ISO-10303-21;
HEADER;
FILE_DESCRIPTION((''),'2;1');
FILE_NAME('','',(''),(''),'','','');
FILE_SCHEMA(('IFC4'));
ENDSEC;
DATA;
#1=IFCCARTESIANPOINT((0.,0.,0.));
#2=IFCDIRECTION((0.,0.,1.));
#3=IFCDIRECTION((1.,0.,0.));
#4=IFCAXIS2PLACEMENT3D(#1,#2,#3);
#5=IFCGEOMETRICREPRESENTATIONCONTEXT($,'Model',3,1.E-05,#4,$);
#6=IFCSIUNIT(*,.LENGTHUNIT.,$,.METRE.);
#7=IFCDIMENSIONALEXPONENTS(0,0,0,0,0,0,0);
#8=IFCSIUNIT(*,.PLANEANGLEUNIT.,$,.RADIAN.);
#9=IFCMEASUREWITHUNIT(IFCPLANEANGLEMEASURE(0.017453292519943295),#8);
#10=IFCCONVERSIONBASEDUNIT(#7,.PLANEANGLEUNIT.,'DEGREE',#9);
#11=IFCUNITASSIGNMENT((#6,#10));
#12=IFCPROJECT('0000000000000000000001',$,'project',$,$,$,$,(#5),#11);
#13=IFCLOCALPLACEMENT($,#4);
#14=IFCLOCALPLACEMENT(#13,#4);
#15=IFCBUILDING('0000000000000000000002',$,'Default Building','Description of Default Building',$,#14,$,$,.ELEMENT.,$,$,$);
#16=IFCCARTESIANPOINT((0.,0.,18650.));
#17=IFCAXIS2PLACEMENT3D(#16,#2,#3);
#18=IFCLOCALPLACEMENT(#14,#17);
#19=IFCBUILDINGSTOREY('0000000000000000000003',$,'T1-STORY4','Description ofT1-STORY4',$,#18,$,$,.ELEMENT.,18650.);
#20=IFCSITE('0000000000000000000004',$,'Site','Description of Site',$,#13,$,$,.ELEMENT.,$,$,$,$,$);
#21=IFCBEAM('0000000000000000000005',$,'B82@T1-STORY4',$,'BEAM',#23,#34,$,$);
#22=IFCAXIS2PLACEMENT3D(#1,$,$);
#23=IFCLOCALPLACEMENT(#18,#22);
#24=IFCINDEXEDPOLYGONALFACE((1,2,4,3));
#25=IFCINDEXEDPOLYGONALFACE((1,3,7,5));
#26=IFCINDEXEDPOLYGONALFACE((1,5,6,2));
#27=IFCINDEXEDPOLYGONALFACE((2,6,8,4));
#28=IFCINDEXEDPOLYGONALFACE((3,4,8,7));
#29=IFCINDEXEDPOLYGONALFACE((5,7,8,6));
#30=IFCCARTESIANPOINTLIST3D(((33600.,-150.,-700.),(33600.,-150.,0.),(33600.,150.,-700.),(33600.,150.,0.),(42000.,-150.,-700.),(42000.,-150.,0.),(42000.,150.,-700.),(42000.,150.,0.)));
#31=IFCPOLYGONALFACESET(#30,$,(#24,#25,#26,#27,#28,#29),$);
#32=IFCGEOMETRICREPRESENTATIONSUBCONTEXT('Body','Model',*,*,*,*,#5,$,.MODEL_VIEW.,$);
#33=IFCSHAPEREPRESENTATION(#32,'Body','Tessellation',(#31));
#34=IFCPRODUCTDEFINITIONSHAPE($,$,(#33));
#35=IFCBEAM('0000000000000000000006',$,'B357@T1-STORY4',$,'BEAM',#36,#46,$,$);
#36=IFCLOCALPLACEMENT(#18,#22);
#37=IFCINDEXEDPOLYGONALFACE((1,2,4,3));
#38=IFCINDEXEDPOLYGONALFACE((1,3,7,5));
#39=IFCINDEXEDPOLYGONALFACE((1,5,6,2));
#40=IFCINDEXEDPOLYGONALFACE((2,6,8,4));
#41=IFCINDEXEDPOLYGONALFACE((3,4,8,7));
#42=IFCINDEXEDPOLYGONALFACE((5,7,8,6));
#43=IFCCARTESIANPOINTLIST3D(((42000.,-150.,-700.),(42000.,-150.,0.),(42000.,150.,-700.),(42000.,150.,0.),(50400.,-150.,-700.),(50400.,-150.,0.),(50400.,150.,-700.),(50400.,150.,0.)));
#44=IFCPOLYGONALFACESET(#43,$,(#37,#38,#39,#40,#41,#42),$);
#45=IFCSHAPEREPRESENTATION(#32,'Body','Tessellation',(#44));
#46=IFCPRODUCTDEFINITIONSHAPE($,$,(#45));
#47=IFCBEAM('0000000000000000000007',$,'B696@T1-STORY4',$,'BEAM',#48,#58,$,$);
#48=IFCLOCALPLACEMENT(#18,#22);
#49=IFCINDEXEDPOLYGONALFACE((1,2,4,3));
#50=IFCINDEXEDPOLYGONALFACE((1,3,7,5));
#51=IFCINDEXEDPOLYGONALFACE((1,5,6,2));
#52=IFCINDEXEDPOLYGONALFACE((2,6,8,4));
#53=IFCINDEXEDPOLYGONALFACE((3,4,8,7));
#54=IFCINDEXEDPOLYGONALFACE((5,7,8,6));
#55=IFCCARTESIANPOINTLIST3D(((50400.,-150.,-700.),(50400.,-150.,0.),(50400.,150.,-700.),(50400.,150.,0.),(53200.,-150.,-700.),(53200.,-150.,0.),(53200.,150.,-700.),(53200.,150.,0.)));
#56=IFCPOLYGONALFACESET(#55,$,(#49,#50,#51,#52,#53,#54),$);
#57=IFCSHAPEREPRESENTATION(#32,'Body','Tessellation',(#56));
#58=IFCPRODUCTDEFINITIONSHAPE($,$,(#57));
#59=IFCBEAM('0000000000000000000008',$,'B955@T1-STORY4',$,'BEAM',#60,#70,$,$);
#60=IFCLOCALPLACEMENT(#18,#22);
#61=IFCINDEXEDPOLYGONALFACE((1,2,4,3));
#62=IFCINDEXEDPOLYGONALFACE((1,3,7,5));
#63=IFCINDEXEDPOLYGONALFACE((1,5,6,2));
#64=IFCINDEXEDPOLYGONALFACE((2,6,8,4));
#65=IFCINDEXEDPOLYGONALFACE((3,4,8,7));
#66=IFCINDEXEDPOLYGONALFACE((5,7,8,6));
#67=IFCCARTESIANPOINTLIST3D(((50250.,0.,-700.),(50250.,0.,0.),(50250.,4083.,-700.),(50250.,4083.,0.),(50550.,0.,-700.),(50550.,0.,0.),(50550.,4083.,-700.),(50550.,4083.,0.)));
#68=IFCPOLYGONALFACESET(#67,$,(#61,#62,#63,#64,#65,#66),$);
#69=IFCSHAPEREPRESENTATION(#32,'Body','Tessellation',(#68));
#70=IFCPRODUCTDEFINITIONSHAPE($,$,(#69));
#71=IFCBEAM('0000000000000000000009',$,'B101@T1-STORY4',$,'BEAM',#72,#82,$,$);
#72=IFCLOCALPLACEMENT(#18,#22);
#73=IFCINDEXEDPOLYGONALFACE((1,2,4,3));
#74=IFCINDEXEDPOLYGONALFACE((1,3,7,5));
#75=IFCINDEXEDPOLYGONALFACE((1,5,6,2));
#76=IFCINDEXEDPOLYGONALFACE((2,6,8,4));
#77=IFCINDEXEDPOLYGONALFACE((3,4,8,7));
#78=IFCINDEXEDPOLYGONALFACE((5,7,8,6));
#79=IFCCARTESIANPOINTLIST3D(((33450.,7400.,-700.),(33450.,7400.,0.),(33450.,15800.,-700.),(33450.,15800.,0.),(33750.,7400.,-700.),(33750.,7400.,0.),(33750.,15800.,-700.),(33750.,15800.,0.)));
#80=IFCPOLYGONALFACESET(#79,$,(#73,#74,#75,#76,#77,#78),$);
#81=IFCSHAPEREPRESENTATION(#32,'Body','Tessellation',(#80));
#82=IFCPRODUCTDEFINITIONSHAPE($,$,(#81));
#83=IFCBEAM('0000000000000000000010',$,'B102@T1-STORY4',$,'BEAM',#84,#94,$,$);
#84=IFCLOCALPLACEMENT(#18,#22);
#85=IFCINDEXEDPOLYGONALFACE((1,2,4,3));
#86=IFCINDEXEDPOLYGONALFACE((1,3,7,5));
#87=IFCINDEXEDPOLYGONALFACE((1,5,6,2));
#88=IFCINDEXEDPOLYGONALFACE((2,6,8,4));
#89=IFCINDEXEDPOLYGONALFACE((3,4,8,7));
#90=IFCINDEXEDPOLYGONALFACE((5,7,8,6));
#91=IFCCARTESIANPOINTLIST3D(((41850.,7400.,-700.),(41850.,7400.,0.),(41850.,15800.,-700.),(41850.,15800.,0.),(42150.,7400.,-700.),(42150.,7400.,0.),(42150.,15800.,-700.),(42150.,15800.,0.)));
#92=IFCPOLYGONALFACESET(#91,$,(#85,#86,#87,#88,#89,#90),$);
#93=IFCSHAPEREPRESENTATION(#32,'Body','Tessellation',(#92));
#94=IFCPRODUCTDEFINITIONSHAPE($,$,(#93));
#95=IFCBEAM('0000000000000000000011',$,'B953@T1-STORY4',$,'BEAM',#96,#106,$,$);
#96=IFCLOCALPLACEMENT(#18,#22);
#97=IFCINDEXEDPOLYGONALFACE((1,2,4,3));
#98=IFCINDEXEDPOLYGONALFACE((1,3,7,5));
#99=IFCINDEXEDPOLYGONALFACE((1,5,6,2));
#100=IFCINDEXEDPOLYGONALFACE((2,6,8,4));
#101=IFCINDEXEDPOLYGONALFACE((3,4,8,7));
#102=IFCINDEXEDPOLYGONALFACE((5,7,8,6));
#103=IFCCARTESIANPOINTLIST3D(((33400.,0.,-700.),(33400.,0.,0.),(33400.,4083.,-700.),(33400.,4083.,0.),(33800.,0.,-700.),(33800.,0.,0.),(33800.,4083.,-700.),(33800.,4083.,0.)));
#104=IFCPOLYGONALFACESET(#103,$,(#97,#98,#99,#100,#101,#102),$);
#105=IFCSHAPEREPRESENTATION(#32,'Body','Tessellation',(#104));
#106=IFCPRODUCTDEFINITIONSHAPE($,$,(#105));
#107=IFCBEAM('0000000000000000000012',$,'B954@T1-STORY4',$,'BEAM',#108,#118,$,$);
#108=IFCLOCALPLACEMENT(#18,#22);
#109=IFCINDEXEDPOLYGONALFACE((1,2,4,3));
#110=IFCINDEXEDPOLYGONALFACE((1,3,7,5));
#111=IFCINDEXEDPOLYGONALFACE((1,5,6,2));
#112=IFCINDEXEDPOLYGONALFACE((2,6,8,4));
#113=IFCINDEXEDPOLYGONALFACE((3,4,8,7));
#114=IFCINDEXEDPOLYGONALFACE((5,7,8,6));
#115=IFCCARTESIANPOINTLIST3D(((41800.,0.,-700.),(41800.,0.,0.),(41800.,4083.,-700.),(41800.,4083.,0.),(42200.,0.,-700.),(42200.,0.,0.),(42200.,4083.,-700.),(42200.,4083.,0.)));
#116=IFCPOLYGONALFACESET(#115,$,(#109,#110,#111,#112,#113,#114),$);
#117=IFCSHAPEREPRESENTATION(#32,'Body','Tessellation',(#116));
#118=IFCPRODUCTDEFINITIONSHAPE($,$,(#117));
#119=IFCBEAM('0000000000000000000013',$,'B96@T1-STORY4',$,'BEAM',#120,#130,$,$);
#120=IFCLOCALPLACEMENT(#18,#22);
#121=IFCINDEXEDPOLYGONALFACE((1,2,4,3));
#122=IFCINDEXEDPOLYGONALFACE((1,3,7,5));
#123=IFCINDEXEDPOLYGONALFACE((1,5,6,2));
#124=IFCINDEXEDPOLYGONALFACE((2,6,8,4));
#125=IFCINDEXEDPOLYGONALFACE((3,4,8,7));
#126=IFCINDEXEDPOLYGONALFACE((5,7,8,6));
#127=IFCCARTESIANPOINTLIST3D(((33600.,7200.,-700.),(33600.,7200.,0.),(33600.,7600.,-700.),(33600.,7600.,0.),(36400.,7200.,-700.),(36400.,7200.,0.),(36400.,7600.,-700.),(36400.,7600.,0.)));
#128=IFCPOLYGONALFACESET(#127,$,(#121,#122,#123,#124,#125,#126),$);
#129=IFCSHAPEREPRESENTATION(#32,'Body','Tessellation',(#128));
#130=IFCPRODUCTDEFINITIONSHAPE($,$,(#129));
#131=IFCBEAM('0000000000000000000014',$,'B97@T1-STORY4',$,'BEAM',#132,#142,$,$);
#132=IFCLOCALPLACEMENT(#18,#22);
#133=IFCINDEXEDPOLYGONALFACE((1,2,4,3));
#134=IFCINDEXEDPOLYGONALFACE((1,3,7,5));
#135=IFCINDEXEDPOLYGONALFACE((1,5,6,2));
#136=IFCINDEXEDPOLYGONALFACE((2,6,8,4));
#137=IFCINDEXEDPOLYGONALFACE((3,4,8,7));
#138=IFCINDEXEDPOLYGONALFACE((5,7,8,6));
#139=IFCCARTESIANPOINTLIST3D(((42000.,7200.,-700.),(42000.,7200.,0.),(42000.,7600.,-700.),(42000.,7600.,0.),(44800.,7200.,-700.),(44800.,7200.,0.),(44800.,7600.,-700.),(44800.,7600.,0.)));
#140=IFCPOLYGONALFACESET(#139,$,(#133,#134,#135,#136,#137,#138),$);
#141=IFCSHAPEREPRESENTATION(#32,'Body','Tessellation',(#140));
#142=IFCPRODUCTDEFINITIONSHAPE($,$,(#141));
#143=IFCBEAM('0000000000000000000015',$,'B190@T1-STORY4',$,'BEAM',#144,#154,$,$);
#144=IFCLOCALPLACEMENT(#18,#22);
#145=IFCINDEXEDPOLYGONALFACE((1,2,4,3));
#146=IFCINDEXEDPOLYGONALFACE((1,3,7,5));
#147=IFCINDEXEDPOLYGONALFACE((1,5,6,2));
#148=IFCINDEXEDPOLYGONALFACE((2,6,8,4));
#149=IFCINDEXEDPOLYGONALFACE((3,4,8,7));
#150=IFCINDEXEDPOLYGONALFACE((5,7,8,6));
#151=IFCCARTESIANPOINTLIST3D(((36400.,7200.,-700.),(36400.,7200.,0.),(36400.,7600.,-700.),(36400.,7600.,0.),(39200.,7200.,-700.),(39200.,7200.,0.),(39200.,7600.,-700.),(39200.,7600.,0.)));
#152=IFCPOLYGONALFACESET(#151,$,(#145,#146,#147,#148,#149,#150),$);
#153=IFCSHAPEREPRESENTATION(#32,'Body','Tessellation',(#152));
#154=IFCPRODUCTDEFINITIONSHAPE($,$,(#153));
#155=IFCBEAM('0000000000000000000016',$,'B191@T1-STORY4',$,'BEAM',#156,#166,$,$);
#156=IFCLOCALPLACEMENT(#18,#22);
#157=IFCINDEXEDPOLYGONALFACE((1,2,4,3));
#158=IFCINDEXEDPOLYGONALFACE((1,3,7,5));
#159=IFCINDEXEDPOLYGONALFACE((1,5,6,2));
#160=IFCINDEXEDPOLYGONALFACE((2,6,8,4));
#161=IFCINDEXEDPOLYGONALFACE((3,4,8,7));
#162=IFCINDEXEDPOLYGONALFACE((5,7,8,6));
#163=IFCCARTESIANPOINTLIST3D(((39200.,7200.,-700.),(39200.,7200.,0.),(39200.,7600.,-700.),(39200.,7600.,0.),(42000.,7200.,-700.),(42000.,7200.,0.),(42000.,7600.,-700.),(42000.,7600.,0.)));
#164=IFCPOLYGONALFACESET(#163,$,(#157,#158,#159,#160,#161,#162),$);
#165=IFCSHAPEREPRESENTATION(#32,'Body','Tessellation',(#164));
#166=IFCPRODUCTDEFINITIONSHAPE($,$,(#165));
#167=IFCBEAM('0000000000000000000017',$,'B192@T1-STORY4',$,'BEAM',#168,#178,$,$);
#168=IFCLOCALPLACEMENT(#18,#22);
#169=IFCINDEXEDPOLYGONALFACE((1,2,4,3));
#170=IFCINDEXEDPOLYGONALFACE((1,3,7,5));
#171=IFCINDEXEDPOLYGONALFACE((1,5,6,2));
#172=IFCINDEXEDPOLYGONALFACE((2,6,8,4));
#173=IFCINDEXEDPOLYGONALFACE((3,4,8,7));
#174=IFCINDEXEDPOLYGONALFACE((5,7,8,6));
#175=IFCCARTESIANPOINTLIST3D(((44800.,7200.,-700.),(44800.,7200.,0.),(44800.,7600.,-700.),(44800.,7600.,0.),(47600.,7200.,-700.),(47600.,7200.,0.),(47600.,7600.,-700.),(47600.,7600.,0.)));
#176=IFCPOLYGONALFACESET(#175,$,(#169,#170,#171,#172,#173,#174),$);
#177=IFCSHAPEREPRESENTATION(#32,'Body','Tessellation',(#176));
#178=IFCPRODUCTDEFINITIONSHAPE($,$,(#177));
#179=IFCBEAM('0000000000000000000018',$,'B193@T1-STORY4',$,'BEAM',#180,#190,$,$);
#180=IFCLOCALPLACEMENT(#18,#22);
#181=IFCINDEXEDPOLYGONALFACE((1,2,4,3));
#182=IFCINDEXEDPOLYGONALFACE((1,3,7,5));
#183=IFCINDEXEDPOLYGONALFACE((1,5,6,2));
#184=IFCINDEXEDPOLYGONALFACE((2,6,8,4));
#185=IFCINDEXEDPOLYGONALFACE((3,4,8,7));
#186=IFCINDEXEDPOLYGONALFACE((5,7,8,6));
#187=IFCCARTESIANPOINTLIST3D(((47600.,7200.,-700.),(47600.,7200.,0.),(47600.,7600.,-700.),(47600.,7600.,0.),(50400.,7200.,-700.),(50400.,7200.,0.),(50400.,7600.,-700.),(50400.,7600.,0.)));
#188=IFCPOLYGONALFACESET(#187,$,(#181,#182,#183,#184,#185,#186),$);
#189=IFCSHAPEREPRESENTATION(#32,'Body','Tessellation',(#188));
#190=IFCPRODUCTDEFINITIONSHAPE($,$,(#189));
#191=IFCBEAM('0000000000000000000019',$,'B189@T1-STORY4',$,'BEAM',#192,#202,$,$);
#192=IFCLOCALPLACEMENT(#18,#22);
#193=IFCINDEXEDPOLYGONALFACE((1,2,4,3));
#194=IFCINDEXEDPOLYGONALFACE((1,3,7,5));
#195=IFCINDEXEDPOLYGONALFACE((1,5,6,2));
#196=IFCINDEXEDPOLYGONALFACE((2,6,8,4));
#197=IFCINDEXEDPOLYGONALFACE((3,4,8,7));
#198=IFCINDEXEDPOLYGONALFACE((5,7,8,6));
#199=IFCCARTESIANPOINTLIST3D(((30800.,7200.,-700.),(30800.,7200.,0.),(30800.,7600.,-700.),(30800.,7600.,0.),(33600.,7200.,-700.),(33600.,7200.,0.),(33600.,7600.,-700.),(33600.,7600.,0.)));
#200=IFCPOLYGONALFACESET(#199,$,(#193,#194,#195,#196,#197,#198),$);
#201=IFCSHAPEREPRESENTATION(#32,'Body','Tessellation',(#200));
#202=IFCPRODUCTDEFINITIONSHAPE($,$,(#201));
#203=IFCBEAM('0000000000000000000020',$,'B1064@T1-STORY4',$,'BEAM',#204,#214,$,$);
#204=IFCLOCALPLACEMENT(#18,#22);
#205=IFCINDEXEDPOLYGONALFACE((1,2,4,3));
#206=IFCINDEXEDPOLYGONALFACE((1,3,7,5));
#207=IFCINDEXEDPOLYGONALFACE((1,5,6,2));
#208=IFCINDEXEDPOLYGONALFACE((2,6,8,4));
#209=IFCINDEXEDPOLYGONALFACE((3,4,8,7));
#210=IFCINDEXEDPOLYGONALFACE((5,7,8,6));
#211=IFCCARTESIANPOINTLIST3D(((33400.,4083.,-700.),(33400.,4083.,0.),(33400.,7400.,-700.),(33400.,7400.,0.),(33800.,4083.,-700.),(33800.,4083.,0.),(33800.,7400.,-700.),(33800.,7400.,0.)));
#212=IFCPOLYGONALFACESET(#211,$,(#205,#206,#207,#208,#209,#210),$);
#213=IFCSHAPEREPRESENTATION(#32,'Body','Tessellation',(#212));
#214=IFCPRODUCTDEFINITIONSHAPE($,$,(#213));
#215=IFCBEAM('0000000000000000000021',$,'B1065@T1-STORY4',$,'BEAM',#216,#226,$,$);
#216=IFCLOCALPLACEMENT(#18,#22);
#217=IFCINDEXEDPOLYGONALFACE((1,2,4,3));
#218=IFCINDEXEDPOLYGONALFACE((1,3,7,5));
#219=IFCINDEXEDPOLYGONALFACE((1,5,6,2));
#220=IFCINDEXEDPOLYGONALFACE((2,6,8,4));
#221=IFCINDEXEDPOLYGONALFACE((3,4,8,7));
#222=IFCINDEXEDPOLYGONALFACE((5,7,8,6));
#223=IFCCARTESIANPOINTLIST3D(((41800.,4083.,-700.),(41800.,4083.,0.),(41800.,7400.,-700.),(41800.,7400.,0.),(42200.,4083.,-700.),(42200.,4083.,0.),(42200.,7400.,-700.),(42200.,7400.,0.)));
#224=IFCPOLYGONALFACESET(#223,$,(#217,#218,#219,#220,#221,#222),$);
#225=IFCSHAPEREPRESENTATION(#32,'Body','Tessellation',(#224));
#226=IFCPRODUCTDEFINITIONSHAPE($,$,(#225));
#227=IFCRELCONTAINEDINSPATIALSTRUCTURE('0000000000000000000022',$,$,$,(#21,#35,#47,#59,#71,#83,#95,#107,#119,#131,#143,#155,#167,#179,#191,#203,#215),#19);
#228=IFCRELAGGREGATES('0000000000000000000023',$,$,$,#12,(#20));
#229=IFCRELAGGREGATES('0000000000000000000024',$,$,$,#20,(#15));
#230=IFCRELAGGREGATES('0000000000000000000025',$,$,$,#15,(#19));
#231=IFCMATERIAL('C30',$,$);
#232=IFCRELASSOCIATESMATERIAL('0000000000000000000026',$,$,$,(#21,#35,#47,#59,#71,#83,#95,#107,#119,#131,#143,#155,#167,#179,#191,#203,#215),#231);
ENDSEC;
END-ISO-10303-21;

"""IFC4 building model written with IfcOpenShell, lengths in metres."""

from ifc_helpers import new_model, entity, si_unit, converted_unit, frame, origin_with_axes, place, context, subcontext, project, spatial, rectangle, extrude, material, element, save


model = new_model("IFC4")

# Units and contexts
model_context = context("Model", 3, precision=1e-05, world=origin_with_axes())
body_context = subcontext(model_context, "Body", "Model", "MODEL_VIEW")
ifc_project = project(units=[si_unit("LENGTHUNIT", "METRE"), converted_unit("PLANEANGLEUNIT", "DEGREE", entity("IfcPlaneAngleMeasure", 0.017453292519943295), si_unit("PLANEANGLEUNIT", "RADIAN"), dimensions=[0, 0, 0, 0, 0, 0, 0])], contexts=[model_context])

# Site, building, storey
site_placement = place(None, origin_with_axes())
site = spatial("IfcSite", under=ifc_project, at=site_placement, Name="Site", Description="Description of Site", CompositionType="ELEMENT")
building_placement = place(site_placement, origin_with_axes())
building = spatial("IfcBuilding", under=site, at=building_placement, Name="Default Building", Description="Description of Default Building", CompositionType="ELEMENT")
storey_placement = place(building_placement, frame((0.0, 0.0, 18650.0), z_axis=(0.0, 0.0, 1.0), x_axis=(1.0, 0.0, 0.0)))
storey = spatial("IfcBuildingStorey", under=building, at=storey_placement, Name="T1-STORY4", Description="Description ofT1-STORY4", CompositionType="ELEMENT", Elevation=18650.0)

# Beams
ifc_material_1 = material(Name="C30")
for number, where, z_axis, x_axis, name in (
    (1, (33600.0, 0.0, -350.0), (1.0, 0.0, 0.0), (0.0, 1.0, 0.0), "B82@T1-STORY4"),
    (2, (42000.0, 0.0, -350.0), (1.0, 0.0, 0.0), (0.0, 1.0, 0.0), "B357@T1-STORY4"),
):
    element("IfcBeam", number, at=place(storey_placement, frame(where, z_axis=z_axis, x_axis=x_axis)), inside=storey, material=ifc_material_1, Name=name, ObjectType="BEAM", context=body_context, shape_type="SweptSolid", body=[
        extrude(rectangle(XDim=300.0, YDim=700.0), origin_with_axes(), (0.0, 0.0, 1.0), 8400.0),
    ])
beam_1_placement = place(storey_placement, frame((50400.0, 0.0, -350.0), z_axis=(1.0, 0.0, 0.0), x_axis=(0.0, 1.0, 0.0)))
element("IfcBeam", 3, at=beam_1_placement, inside=storey, material=ifc_material_1, Name="B696@T1-STORY4", ObjectType="BEAM", context=body_context, shape_type="SweptSolid", body=[
    extrude(rectangle(XDim=300.0, YDim=700.0), origin_with_axes(), (0.0, 0.0, 1.0), 2800.0),
])
beam_2_placement = place(storey_placement, frame((50400.0, 0.0, -350.0), z_axis=(0.0, 1.0, 0.0), x_axis=(-1.0, 0.0, 0.0)))
element("IfcBeam", 4, at=beam_2_placement, inside=storey, material=ifc_material_1, Name="B955@T1-STORY4", ObjectType="BEAM", context=body_context, shape_type="SweptSolid", body=[
    extrude(rectangle(XDim=300.0, YDim=700.0), origin_with_axes(), (0.0, 0.0, 1.0), 4083.0),
])
for number, where, z_axis, x_axis, name in (
    (5, (33600.0, 7400.0, -350.0), (0.0, 1.0, 0.0), (-1.0, 0.0, 0.0), "B101@T1-STORY4"),
    (6, (42000.0, 7400.0, -350.0), (0.0, 1.0, 0.0), (-1.0, 0.0, 0.0), "B102@T1-STORY4"),
):
    element("IfcBeam", number, at=place(storey_placement, frame(where, z_axis=z_axis, x_axis=x_axis)), inside=storey, material=ifc_material_1, Name=name, ObjectType="BEAM", context=body_context, shape_type="SweptSolid", body=[
        extrude(rectangle(XDim=300.0, YDim=700.0), origin_with_axes(), (0.0, 0.0, 1.0), 8400.0),
    ])
for number, where, z_axis, x_axis, name in (
    (7, (33600.0, 0.0, -350.0), (0.0, 1.0, 0.0), (-1.0, 0.0, 0.0), "B953@T1-STORY4"),
    (8, (42000.0, 0.0, -350.0), (0.0, 1.0, 0.0), (-1.0, 0.0, 0.0), "B954@T1-STORY4"),
):
    element("IfcBeam", number, at=place(storey_placement, frame(where, z_axis=z_axis, x_axis=x_axis)), inside=storey, material=ifc_material_1, Name=name, ObjectType="BEAM", context=body_context, shape_type="SweptSolid", body=[
        extrude(rectangle(XDim=400.0, YDim=700.0), origin_with_axes(), (0.0, 0.0, 1.0), 4083.0),
    ])
for number, where, z_axis, x_axis, name in (
    (9, (33600.0, 7400.0, -350.0), (1.0, 0.0, 0.0), (0.0, 1.0, 0.0), "B96@T1-STORY4"),
    (10, (42000.0, 7400.0, -350.0), (1.0, 0.0, 0.0), (0.0, 1.0, 0.0), "B97@T1-STORY4"),
    (11, (36400.0, 7400.0, -350.0), (1.0, 0.0, 0.0), (0.0, 1.0, 0.0), "B190@T1-STORY4"),
    (12, (39200.0, 7400.0, -350.0), (1.0, 0.0, 0.0), (0.0, 1.0, 0.0), "B191@T1-STORY4"),
    (13, (44800.0, 7400.0, -350.0), (1.0, 0.0, 0.0), (0.0, 1.0, 0.0), "B192@T1-STORY4"),
    (14, (47600.0, 7400.0, -350.0), (1.0, 0.0, 0.0), (0.0, 1.0, 0.0), "B193@T1-STORY4"),
    (15, (30800.0, 7400.0, -350.0), (1.0, 0.0, 0.0), (0.0, 1.0, 0.0), "B189@T1-STORY4"),
):
    element("IfcBeam", number, at=place(storey_placement, frame(where, z_axis=z_axis, x_axis=x_axis)), inside=storey, material=ifc_material_1, Name=name, ObjectType="BEAM", context=body_context, shape_type="SweptSolid", body=[
        extrude(rectangle(XDim=400.0, YDim=700.0), origin_with_axes(), (0.0, 0.0, 1.0), 2800.0),
    ])
for number, where, z_axis, x_axis, name in (
    (16, (33600.0, 4083.0, -350.0), (0.0, 1.0, 0.0), (-1.0, 0.0, 0.0), "B1064@T1-STORY4"),
    (17, (42000.0, 4083.0, -350.0), (0.0, 1.0, 0.0), (-1.0, 0.0, 0.0), "B1065@T1-STORY4"),
):
    element("IfcBeam", number, at=place(storey_placement, frame(where, z_axis=z_axis, x_axis=x_axis)), inside=storey, material=ifc_material_1, Name=name, ObjectType="BEAM", context=body_context, shape_type="SweptSolid", body=[
        extrude(rectangle(XDim=400.0, YDim=700.0), origin_with_axes(), (0.0, 0.0, 1.0), 3317.0),
    ])

save(model, "model.ifc")
